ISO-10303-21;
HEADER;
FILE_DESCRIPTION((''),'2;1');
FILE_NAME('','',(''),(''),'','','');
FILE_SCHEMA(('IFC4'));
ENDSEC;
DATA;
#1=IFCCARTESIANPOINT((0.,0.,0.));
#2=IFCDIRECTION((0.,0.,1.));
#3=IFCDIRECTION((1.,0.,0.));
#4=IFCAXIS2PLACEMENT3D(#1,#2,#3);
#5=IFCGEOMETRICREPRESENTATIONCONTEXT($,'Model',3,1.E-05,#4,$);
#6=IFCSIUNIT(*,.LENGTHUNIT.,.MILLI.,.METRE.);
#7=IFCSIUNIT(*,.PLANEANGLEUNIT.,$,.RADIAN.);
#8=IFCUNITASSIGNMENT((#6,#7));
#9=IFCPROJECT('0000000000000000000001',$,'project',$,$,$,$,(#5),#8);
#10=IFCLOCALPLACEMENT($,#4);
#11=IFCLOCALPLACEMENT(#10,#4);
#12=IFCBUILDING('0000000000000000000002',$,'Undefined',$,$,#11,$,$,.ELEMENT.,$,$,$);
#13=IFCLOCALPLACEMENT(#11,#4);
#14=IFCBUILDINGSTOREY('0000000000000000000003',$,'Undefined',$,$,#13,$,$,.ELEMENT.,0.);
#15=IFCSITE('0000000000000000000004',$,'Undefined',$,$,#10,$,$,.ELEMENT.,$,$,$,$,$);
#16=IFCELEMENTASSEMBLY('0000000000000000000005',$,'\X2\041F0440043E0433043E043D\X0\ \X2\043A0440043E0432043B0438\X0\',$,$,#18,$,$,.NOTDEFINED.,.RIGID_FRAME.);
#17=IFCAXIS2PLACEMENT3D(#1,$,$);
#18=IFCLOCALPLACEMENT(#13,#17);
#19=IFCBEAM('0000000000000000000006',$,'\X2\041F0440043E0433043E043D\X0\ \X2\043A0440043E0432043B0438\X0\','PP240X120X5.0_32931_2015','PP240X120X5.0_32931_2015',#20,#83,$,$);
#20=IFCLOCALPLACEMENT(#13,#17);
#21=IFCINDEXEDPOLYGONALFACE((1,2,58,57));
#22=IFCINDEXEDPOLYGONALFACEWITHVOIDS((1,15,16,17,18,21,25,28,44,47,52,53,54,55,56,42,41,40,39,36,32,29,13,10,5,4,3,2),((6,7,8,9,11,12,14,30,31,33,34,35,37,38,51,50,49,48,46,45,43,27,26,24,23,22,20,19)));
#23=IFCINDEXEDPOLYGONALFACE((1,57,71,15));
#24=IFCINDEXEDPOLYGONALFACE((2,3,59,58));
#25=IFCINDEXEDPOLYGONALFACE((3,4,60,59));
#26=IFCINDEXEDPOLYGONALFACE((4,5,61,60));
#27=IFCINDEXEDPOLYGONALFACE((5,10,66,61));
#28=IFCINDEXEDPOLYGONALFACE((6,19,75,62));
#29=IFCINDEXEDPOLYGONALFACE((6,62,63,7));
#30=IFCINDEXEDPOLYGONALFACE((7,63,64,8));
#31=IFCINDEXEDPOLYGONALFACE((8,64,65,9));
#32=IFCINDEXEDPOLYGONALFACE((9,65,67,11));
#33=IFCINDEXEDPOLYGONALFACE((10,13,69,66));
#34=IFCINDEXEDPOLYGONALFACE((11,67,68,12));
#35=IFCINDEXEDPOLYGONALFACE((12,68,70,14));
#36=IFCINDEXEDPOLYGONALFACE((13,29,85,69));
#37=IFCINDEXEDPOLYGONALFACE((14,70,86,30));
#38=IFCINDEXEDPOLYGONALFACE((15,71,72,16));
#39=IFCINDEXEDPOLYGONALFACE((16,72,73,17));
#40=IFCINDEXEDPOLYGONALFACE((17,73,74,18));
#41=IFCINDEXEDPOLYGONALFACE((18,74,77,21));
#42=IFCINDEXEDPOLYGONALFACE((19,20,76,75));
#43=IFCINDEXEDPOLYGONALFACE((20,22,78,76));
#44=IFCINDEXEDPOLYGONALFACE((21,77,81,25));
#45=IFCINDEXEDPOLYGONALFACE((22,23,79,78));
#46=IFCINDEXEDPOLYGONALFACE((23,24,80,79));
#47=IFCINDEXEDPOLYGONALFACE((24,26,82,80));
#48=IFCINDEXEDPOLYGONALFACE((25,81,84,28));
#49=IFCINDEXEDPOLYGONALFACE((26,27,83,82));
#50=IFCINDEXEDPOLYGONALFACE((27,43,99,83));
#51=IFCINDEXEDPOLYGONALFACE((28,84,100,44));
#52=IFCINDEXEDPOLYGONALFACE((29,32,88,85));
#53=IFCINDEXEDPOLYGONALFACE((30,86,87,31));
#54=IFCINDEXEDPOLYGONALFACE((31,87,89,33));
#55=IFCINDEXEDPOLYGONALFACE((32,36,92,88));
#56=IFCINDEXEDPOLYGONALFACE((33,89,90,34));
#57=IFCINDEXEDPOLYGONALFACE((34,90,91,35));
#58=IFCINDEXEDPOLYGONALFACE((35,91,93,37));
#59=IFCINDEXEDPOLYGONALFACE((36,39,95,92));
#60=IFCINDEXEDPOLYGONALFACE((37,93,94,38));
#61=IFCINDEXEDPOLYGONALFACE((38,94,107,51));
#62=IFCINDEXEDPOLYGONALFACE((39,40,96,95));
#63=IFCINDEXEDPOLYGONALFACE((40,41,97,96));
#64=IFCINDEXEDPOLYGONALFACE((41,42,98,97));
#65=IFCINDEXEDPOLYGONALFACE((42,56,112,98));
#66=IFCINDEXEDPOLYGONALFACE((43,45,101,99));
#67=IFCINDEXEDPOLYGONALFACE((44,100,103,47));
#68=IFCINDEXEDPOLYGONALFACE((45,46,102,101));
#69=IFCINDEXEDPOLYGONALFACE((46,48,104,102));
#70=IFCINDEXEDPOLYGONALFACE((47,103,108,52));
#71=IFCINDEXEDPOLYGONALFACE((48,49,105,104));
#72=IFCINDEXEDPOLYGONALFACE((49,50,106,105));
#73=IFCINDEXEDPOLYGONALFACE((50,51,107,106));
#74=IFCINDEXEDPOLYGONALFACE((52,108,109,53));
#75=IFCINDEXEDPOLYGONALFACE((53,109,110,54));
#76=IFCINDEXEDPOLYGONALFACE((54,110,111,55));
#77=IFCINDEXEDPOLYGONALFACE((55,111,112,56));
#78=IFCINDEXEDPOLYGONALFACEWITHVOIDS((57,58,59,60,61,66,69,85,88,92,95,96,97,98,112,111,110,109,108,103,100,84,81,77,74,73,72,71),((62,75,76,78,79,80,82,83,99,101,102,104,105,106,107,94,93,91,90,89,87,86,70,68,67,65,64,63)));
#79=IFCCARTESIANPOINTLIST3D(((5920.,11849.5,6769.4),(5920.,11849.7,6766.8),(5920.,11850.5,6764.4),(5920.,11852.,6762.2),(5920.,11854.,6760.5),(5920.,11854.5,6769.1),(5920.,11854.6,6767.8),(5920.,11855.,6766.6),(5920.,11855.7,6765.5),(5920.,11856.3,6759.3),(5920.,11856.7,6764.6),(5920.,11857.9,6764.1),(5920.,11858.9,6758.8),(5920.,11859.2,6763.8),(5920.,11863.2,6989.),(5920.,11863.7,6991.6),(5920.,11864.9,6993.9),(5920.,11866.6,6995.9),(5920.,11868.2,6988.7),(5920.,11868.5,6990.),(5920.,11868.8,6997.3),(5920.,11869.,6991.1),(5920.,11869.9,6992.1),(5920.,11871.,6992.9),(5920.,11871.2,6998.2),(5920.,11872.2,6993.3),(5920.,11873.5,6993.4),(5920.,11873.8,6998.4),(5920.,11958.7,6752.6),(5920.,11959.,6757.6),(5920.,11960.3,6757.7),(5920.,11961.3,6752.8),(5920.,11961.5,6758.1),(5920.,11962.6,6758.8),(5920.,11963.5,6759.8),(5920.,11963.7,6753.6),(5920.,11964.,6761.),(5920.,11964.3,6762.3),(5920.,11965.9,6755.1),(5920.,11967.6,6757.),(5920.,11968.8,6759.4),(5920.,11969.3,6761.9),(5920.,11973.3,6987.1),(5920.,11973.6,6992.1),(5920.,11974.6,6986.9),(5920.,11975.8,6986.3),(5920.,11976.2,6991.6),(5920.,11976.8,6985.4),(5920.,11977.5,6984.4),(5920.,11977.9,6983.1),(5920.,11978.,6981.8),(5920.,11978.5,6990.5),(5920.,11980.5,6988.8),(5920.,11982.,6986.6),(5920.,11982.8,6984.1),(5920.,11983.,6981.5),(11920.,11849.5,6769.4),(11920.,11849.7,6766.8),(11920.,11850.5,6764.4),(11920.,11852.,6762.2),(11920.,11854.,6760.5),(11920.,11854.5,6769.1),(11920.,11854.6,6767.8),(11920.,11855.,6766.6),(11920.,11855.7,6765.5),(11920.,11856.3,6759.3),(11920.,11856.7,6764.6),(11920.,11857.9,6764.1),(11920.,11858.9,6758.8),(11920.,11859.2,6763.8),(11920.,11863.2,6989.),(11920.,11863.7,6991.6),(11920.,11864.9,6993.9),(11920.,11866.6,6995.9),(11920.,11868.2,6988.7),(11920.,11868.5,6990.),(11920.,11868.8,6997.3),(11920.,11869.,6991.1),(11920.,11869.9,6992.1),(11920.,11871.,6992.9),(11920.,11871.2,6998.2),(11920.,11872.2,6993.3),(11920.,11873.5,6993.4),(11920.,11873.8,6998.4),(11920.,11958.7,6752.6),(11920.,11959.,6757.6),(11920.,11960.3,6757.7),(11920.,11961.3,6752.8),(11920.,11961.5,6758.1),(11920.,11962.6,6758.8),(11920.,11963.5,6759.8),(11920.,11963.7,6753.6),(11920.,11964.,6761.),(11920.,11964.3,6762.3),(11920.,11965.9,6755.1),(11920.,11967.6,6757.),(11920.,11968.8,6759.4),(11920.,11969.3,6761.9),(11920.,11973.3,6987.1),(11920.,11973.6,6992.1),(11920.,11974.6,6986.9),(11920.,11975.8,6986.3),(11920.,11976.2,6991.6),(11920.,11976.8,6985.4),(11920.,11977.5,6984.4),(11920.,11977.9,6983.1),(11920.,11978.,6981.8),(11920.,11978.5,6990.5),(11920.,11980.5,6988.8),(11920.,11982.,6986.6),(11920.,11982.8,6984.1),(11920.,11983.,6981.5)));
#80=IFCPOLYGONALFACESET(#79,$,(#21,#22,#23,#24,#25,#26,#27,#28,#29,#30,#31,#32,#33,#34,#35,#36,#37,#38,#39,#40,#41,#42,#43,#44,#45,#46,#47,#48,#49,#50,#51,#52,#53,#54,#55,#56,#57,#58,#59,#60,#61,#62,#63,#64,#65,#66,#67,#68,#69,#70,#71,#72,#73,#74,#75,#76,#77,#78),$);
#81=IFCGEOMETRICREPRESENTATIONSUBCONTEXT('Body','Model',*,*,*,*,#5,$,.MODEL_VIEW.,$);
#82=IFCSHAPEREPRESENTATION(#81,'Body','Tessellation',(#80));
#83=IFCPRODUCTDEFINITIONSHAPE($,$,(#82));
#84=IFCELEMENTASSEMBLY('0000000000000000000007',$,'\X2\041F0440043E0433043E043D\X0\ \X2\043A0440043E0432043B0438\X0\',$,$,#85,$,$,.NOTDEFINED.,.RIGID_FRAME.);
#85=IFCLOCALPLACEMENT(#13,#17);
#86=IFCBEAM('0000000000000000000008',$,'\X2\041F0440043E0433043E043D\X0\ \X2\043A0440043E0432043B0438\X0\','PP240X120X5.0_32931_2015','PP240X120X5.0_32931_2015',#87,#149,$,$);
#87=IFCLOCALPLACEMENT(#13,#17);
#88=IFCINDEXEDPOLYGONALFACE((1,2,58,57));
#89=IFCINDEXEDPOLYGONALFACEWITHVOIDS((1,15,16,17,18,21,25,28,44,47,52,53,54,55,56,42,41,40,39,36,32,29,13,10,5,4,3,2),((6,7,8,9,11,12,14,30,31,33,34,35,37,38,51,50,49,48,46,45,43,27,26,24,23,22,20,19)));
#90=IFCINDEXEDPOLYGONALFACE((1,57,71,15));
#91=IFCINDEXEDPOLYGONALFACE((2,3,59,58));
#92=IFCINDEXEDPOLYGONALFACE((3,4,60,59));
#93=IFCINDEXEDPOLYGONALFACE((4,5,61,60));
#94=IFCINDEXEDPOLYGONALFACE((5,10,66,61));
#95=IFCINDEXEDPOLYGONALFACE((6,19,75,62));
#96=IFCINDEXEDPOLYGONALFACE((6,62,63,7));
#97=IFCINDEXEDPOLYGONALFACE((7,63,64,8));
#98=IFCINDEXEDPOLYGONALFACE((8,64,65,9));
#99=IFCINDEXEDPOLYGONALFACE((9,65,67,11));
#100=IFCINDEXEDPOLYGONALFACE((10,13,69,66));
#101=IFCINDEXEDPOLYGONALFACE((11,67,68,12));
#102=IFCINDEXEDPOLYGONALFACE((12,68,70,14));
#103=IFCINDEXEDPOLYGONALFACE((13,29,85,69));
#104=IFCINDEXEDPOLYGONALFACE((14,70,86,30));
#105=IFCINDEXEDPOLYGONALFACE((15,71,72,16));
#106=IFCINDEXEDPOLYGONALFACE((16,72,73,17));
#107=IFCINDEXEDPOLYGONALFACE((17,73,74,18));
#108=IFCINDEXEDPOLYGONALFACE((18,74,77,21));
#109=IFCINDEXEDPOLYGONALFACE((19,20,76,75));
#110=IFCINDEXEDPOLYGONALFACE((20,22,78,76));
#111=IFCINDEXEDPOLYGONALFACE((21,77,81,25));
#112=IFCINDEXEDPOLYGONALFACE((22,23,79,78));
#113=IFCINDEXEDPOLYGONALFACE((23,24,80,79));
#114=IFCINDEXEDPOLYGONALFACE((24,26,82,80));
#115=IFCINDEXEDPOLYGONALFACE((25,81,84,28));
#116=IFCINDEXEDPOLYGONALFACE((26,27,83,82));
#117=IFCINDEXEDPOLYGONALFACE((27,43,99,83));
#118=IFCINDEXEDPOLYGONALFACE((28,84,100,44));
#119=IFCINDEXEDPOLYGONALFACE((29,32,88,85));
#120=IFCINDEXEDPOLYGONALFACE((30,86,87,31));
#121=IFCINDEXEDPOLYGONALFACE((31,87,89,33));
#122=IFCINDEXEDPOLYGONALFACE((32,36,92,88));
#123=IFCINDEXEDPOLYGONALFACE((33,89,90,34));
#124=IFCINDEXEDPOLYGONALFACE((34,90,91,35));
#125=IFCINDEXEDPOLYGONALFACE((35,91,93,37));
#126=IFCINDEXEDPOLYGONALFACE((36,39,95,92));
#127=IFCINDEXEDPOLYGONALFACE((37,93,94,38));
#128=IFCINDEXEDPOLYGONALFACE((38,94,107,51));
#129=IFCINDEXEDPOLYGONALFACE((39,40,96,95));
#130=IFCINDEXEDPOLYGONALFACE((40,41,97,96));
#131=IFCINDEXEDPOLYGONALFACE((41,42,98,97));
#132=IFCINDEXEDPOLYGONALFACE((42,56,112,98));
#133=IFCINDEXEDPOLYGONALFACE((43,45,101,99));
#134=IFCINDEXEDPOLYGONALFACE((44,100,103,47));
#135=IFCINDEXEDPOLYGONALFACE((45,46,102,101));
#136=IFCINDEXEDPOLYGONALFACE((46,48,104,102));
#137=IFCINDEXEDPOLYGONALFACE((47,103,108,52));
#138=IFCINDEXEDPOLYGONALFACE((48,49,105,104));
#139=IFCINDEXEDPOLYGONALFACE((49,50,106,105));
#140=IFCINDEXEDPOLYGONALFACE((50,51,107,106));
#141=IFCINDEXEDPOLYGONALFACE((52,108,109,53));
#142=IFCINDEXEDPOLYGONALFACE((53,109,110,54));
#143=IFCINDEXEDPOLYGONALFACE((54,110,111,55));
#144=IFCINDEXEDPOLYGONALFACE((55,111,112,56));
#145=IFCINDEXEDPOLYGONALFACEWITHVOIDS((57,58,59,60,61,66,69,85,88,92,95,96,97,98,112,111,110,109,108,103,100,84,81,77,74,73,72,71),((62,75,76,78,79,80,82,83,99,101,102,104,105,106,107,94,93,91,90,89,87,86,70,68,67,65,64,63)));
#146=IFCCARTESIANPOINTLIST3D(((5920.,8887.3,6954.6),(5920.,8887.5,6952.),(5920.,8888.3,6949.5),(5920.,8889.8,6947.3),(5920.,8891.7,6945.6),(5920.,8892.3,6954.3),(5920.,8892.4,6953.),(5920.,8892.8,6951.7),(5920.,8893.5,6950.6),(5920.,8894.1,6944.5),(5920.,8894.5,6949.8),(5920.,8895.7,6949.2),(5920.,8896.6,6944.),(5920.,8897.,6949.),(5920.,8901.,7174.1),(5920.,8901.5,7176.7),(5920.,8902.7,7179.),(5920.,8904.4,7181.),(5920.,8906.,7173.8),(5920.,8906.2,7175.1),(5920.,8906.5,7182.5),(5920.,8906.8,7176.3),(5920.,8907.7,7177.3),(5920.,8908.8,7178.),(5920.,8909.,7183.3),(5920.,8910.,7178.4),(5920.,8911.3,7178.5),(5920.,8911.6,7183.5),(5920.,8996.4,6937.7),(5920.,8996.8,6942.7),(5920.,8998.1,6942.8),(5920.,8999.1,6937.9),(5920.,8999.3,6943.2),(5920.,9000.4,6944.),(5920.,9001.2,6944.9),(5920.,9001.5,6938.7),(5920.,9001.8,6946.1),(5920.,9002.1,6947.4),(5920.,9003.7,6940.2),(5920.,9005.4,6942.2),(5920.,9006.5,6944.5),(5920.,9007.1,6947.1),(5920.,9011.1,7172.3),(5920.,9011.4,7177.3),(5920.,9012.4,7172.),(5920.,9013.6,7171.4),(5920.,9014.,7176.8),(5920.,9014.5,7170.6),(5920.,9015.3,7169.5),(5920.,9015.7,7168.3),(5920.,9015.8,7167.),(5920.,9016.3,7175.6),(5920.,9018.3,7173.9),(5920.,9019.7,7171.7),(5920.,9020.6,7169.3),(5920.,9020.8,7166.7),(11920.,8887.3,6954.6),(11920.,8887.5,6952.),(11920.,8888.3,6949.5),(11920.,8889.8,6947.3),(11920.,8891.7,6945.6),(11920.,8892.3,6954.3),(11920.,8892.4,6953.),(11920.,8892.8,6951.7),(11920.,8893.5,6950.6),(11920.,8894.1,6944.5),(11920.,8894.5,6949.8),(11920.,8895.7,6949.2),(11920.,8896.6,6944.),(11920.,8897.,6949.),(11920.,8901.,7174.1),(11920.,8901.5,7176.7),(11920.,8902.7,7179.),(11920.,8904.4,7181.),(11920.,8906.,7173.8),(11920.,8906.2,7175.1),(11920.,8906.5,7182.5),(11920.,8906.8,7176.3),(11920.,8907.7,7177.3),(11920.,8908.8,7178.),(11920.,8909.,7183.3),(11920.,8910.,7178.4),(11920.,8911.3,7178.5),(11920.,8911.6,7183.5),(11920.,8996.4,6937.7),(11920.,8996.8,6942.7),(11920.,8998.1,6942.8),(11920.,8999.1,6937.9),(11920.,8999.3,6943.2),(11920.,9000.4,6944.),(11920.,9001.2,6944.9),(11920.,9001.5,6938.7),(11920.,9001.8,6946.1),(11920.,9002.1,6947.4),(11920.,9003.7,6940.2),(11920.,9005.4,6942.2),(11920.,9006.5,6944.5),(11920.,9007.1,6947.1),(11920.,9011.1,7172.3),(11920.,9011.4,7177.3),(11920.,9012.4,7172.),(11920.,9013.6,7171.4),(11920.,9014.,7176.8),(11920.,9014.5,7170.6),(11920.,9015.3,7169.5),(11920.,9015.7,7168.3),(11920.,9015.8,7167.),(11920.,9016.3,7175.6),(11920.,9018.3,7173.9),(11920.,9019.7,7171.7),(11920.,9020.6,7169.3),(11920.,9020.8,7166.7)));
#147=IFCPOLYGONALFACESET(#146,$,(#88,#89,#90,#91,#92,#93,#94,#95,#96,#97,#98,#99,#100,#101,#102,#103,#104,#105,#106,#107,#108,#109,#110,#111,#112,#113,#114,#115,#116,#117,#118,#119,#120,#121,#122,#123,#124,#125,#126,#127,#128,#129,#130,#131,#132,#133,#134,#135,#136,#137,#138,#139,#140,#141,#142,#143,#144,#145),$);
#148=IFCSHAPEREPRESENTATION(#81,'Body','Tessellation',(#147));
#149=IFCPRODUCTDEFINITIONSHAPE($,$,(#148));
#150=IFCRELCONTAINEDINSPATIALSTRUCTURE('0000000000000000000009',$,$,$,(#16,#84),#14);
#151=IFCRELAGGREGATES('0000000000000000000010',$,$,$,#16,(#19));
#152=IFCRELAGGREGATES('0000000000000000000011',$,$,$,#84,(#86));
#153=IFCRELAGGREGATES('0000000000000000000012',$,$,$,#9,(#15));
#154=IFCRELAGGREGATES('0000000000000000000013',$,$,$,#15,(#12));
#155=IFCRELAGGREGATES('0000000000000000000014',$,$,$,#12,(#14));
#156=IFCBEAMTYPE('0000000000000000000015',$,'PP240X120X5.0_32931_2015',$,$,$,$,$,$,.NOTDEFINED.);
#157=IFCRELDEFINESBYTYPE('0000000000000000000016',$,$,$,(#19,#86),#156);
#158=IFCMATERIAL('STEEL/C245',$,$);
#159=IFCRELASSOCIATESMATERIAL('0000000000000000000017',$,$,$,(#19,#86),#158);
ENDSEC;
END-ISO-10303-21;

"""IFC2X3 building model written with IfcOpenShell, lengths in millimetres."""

from ifc_helpers import new_model, si_unit, frame, origin_with_axes, origin_2d_with_axis, place, context, subcontext, project, spatial, hollow_rectangle, extrude, material, type_object, element, aggregate, save


model = new_model("IFC2X3")

# Units and contexts
model_context = context("Model", 3, precision=1e-05, world=origin_with_axes())
body_context = subcontext(model_context, "Body", "Model", "MODEL_VIEW")
ifc_project = project(units=[si_unit("LENGTHUNIT", "METRE", prefix="MILLI"), si_unit("PLANEANGLEUNIT", "RADIAN")], contexts=[model_context])

# Site, building, storey
site_placement = place(None, origin_with_axes())
site = spatial("IfcSite", under=ifc_project, at=site_placement, Name="Undefined", CompositionType="ELEMENT")
building_placement = place(site_placement, origin_with_axes())
building = spatial("IfcBuilding", under=site, at=building_placement, Name="Undefined", CompositionType="ELEMENT")
storey_placement = place(building_placement, origin_with_axes())
storey = spatial("IfcBuildingStorey", under=building, at=storey_placement, Name="Undefined", CompositionType="ELEMENT", Elevation=0.0)

# Shared definitions
ifc_material = material(Name="STEEL/C245")

# Element assemblies, beams
assembly_1_placement = place(storey_placement, origin_with_axes())
assembly_1 = element("IfcElementAssembly", 1, at=assembly_1_placement, inside=storey, Name="Прогон кровли", AssemblyPlace="NOTDEFINED", PredefinedType="RIGID_FRAME")
beam_type_1 = type_object("IfcBeamType", Name="PP240X120X5.0_32931_2015", PredefinedType="NOTDEFINED")
beam_1_placement = place(assembly_1_placement, frame((11920.0, 11916.2, 6875.5), z_axis=(0.0, 0.062378, 0.998053), x_axis=(-1.0, 0.0, 0.0)))
beam_1 = element("IfcBeam", 2, at=beam_1_placement, type_object=beam_type_1, material=ifc_material, Name="Прогон кровли", Description="PP240X120X5.0_32931_2015", ObjectType="PP240X120X5.0_32931_2015", context=body_context, shape_type="SweptSolid", body=[
    extrude(hollow_rectangle(XDim=120.0, YDim=240.0, WallThickness=5.0, InnerFilletRadius=5.0, OuterFilletRadius=10.0, at=origin_2d_with_axis()), frame((6000.0, 0.0, 0.0), z_axis=(-1.0, 0.0, 0.0), x_axis=(0.0, -1.0, 0.0)), (0.0, 0.0, 1.0), 6000.0),
])
aggregate(assembly_1, [beam_1])
assembly_2_placement = place(storey_placement, origin_with_axes())
assembly_2 = element("IfcElementAssembly", 3, at=assembly_2_placement, inside=storey, Name="Прогон кровли", AssemblyPlace="NOTDEFINED", PredefinedType="RIGID_FRAME")
beam_2_placement = place(assembly_2_placement, frame((11920.0, 8954.0, 7060.6), z_axis=(0.0, 0.062378, 0.998053), x_axis=(-1.0, 0.0, 0.0)))
beam_2 = element("IfcBeam", 4, at=beam_2_placement, type_object=beam_type_1, material=ifc_material, Name="Прогон кровли", Description="PP240X120X5.0_32931_2015", ObjectType="PP240X120X5.0_32931_2015", context=body_context, shape_type="SweptSolid", body=[
    extrude(hollow_rectangle(XDim=120.0, YDim=240.0, WallThickness=5.0, InnerFilletRadius=5.0, OuterFilletRadius=10.0, at=origin_2d_with_axis()), frame((6000.0, 0.0, 0.0), z_axis=(-1.0, 0.0, 0.0), x_axis=(0.0, -1.0, 0.0)), (0.0, 0.0, 1.0), 6000.0),
])
aggregate(assembly_2, [beam_2])

save(model, "model.ifc")
